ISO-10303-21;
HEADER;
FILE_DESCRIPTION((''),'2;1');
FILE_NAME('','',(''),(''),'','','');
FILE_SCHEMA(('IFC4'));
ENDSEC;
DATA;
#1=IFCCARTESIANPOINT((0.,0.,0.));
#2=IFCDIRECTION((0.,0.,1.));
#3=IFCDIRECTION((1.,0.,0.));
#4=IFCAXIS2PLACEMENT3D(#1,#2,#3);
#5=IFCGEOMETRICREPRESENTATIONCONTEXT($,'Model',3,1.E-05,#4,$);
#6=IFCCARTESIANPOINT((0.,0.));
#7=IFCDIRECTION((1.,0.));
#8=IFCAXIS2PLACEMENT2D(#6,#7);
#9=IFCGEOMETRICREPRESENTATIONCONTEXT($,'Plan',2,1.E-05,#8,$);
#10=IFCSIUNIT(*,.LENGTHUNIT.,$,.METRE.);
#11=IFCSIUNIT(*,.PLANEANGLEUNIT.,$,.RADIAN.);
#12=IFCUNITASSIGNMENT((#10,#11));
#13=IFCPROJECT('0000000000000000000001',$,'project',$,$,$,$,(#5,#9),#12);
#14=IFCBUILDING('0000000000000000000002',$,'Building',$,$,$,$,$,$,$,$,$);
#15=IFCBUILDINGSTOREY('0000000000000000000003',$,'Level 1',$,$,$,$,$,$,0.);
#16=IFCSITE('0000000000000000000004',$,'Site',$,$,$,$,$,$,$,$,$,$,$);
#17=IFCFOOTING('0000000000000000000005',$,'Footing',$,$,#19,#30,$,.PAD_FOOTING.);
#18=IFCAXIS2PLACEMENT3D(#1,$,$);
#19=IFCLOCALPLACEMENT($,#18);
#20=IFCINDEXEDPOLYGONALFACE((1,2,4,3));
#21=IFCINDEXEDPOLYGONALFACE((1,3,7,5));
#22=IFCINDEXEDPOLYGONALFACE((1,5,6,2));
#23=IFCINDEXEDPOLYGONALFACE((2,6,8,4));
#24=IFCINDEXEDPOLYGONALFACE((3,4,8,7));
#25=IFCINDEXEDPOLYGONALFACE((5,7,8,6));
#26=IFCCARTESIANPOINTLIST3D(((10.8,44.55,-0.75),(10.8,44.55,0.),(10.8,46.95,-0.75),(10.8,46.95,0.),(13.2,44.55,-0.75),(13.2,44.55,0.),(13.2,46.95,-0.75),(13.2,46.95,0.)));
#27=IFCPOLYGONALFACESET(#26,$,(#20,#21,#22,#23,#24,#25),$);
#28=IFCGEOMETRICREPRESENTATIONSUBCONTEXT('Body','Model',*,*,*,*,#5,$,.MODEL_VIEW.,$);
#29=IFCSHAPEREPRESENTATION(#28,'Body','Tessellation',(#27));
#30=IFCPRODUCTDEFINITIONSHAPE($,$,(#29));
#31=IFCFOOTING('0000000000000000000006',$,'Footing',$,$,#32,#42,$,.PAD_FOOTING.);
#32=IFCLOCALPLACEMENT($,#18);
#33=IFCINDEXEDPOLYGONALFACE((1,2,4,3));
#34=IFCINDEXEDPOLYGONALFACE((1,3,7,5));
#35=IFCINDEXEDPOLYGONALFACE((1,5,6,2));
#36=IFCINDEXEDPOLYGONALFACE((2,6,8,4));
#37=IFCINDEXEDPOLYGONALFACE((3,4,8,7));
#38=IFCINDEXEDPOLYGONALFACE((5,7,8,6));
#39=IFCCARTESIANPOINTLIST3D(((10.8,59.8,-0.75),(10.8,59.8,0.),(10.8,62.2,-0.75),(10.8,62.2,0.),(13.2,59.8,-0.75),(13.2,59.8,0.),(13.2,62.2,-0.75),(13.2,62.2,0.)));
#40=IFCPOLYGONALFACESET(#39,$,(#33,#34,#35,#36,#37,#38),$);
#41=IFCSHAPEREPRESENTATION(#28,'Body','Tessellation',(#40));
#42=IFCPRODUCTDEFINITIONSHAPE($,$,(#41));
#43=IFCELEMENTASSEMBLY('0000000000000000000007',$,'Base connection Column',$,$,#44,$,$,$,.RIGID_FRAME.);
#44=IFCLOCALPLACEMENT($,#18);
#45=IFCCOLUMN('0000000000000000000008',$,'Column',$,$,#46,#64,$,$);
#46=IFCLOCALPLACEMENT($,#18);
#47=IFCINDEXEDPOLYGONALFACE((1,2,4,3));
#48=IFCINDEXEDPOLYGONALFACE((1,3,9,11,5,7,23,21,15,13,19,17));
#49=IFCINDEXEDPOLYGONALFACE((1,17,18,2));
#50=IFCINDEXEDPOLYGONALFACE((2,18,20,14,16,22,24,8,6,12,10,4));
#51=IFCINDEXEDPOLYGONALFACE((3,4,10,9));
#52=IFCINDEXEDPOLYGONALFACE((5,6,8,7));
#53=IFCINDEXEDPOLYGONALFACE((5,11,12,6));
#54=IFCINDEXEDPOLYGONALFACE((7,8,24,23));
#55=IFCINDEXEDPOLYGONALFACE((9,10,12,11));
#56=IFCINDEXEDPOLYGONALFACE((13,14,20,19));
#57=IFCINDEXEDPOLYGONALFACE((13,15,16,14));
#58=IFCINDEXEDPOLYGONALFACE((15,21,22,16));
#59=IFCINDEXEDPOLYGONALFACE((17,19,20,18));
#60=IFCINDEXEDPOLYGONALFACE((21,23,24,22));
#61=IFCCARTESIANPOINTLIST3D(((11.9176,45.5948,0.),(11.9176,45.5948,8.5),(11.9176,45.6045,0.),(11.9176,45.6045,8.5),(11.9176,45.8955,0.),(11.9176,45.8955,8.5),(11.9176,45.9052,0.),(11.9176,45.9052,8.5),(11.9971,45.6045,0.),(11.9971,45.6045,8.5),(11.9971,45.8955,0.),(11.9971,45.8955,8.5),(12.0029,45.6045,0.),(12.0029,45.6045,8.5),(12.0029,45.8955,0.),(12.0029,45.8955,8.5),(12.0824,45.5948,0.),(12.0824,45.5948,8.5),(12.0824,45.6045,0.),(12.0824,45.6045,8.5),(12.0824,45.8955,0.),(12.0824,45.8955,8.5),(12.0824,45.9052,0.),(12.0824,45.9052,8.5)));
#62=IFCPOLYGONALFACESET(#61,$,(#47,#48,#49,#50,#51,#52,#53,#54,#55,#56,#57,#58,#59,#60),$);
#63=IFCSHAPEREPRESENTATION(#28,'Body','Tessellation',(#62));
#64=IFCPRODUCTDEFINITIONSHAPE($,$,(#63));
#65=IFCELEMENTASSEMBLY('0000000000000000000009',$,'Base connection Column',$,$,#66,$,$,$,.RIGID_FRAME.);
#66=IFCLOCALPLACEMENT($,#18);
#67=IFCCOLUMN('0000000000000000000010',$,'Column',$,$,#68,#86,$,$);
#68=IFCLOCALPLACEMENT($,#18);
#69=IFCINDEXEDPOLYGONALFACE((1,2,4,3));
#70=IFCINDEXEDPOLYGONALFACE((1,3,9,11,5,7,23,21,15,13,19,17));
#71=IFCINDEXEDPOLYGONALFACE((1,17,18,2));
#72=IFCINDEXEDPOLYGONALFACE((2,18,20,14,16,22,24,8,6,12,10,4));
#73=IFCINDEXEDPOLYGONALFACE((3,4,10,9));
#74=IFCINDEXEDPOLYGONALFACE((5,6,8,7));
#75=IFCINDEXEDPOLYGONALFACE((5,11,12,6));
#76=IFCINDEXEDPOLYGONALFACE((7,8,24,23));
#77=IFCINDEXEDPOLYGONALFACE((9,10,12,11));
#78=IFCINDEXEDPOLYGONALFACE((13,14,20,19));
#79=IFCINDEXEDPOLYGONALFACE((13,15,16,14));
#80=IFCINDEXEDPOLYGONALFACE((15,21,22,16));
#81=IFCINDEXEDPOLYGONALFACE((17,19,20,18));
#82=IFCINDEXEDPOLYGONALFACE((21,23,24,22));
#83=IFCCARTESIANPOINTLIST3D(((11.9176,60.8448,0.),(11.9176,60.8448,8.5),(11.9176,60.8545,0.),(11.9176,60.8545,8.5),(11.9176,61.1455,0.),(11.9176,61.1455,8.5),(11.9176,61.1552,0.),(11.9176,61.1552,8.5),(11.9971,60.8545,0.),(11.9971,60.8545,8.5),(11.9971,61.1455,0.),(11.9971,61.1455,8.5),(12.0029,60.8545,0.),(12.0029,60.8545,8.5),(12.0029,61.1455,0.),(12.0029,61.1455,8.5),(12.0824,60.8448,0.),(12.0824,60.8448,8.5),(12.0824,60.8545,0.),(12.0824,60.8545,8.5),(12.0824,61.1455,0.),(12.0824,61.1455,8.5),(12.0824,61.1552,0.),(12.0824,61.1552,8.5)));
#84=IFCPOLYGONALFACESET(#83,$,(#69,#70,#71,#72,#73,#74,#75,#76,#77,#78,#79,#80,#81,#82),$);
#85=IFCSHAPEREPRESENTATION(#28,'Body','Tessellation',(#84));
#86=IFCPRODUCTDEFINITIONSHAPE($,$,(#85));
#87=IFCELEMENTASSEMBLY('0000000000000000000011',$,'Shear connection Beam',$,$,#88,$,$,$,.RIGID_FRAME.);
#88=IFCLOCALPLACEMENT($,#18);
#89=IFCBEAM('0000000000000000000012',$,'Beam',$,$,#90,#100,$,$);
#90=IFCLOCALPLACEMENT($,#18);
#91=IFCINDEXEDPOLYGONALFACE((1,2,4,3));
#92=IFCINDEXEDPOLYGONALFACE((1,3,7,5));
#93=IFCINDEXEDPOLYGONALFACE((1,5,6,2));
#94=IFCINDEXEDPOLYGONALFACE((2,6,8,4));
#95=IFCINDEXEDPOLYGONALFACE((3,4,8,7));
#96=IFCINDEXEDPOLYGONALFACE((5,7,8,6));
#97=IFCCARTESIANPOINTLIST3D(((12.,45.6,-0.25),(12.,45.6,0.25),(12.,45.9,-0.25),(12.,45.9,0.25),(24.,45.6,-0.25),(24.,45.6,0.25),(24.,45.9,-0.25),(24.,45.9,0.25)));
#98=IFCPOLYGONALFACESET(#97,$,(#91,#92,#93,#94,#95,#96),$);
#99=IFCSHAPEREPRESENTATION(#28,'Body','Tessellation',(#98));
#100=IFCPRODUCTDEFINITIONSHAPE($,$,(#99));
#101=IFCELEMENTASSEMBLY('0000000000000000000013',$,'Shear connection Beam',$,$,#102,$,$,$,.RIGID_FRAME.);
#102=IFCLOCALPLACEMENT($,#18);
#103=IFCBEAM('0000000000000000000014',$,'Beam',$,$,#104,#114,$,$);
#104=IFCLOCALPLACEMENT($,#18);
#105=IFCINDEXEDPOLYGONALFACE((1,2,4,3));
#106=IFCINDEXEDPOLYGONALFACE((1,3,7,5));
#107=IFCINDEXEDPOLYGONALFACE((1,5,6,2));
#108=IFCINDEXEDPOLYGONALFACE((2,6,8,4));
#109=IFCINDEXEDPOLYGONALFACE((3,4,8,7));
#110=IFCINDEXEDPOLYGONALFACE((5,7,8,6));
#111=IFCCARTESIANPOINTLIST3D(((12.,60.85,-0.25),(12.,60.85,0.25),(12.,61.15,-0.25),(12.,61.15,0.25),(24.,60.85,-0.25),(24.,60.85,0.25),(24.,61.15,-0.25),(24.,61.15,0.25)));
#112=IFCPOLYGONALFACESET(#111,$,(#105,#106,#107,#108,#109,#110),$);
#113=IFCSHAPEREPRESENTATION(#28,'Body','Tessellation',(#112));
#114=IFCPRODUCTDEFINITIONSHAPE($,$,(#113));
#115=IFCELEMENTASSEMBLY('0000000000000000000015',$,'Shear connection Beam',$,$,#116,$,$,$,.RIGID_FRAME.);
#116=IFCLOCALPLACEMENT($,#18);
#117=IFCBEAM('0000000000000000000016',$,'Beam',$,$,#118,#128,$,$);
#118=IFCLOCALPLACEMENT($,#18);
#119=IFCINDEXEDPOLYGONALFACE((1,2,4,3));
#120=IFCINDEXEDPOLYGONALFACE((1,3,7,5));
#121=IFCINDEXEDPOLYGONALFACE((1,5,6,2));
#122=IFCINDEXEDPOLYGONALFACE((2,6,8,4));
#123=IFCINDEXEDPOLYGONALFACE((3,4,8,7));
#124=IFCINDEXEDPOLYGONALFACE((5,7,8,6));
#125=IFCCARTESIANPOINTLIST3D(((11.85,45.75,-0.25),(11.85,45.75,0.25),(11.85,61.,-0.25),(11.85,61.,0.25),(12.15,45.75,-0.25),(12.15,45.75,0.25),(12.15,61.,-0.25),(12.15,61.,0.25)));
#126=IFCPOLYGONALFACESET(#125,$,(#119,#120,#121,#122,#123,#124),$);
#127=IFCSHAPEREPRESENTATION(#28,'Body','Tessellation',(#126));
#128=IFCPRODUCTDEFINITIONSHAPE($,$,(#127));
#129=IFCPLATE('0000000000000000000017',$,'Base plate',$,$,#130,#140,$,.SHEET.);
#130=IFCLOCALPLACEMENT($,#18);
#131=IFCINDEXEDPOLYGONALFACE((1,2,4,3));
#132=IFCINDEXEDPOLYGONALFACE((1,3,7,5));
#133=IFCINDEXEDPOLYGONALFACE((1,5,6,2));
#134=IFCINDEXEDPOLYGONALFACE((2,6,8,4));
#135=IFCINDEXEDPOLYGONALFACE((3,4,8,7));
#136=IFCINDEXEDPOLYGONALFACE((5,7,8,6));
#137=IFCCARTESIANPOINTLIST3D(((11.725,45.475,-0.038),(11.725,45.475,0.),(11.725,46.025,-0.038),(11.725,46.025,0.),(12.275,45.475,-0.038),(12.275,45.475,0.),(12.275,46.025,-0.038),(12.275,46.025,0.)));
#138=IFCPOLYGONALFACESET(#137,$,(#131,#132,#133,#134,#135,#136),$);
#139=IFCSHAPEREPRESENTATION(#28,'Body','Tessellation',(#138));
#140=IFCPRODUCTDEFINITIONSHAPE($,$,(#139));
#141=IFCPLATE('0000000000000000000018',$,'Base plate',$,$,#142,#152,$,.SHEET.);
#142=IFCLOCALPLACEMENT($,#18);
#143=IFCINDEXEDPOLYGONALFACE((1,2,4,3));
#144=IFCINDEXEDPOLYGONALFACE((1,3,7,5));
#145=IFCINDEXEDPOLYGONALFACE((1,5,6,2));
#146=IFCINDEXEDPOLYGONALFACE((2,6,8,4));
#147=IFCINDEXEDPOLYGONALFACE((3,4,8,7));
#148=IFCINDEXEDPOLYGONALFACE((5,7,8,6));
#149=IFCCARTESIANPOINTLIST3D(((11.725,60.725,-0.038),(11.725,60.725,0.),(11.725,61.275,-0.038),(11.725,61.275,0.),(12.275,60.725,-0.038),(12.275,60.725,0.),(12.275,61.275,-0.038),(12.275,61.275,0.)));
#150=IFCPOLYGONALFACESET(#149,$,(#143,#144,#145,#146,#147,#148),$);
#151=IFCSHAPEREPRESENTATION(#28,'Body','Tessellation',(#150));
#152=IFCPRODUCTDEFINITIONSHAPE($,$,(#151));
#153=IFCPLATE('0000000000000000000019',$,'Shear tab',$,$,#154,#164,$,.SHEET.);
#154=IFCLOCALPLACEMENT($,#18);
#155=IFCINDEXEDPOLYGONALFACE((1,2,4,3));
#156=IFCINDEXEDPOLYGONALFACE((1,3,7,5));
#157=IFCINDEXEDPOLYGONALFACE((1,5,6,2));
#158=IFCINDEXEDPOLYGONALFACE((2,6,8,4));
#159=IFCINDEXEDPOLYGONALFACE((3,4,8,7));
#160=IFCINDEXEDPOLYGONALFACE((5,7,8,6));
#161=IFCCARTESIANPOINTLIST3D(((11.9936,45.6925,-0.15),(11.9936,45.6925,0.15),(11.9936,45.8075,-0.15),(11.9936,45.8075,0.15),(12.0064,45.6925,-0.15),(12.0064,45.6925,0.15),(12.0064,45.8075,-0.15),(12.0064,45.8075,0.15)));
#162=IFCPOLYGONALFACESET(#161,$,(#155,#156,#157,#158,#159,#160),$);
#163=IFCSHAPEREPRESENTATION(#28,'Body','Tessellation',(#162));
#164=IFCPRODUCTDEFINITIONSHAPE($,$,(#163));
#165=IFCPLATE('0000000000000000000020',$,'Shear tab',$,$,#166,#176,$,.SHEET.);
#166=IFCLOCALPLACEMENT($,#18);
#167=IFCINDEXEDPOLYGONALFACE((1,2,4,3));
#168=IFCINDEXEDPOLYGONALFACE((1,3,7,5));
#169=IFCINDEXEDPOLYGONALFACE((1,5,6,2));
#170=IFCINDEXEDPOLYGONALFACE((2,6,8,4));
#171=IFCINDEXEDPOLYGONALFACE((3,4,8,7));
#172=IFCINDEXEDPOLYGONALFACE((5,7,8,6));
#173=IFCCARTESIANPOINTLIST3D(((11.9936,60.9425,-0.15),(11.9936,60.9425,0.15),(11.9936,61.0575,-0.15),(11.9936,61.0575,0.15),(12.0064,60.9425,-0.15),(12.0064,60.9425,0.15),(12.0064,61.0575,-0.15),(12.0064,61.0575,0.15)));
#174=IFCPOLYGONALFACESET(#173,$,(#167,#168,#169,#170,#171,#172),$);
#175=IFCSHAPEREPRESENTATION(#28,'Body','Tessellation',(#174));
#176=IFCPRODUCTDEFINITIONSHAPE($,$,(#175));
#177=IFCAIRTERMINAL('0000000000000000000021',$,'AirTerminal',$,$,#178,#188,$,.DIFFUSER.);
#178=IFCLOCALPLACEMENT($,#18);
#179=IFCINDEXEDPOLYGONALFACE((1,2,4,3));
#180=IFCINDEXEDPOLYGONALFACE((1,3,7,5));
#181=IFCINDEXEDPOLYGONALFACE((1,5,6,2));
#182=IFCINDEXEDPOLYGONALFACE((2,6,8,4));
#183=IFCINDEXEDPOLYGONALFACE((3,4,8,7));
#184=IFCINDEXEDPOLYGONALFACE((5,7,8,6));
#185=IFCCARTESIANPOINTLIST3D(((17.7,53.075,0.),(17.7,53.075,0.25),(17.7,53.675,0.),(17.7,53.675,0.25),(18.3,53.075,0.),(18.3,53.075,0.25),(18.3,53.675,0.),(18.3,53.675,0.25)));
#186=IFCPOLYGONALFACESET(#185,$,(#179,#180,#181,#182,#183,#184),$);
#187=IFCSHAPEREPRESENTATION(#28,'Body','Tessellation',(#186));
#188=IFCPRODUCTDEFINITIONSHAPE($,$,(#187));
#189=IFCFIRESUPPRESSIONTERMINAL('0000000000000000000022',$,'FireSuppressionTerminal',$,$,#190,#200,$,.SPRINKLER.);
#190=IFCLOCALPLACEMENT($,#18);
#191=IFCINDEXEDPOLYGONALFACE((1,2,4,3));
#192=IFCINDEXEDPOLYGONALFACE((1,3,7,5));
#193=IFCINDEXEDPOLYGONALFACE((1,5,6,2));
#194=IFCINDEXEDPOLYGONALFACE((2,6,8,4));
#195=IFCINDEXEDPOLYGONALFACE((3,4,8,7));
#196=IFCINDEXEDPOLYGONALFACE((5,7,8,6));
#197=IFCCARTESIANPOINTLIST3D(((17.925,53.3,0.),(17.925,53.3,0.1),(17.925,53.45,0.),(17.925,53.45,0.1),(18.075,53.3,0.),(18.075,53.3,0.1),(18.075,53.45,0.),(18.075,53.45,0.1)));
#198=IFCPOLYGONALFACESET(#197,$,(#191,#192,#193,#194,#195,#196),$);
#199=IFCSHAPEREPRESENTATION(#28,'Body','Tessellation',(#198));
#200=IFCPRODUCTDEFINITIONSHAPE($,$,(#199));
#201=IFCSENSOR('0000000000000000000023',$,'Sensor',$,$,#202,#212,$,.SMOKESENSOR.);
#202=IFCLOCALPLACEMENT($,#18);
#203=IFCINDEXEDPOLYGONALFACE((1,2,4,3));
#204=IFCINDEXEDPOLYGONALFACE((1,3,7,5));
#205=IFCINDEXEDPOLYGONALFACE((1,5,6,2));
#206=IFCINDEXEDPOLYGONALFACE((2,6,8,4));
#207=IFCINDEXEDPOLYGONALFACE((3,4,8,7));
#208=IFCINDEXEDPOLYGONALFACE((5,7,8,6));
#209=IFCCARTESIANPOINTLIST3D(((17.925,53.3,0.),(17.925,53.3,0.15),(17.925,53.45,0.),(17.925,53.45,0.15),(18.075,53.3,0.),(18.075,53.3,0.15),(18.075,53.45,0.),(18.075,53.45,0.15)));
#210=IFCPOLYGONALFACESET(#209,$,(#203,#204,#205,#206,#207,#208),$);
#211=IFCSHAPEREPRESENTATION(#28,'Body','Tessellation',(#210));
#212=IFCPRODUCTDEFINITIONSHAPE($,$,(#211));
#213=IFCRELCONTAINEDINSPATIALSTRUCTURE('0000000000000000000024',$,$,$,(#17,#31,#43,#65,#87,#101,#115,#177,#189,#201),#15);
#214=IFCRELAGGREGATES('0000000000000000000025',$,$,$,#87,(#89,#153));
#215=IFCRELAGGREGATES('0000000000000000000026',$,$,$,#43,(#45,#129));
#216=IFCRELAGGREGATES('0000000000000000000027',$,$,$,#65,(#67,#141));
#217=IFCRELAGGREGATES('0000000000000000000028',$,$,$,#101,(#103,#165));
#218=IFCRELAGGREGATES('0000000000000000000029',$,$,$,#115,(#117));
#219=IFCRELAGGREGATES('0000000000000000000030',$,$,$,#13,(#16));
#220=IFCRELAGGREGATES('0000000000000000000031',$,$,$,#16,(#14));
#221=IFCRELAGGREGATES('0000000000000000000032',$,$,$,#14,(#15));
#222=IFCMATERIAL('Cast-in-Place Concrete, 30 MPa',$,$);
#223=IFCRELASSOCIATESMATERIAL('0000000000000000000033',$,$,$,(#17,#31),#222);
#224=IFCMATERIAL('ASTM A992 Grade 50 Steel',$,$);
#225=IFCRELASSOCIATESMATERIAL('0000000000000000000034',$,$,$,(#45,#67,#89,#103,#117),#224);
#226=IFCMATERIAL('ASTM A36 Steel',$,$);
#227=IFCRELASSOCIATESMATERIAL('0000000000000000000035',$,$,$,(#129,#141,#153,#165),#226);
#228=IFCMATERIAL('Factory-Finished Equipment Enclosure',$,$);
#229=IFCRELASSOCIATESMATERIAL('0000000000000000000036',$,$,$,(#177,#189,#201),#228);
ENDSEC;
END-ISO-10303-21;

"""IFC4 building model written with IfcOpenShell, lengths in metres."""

from ifc_helpers import new_model, si_unit, frame, origin_with_axes, origin_2d_with_axis, place, context, subcontext, project, spatial, rectangle, i_section, extrude, material, element, aggregate, save


model = new_model("IFC4")

# Units and contexts
model_context = context("Model", 3, precision=1e-05, world=origin_with_axes())
plan_context = context("Plan", 2, precision=1e-05, world=origin_2d_with_axis())
body_context = subcontext(model_context, "Body", "Model", "MODEL_VIEW")
ifc_project = project(units=[si_unit("LENGTHUNIT", "METRE"), si_unit("PLANEANGLEUNIT", "RADIAN")], contexts=[model_context, plan_context])

# Site, building, storey
site = spatial("IfcSite", under=ifc_project, Name="Site")
building = spatial("IfcBuilding", under=site, Name="Building")
storey = spatial("IfcBuildingStorey", under=building, Name="Level 1", Elevation=0.0)

# Footings
ifc_material_1 = material(Name="Cast-in-Place Concrete, 30 MPa")
for number, where, z_axis, x_axis, name in (
    (1, (12.0, 45.75, -0.75), (0.0, 0.0, 1.0), (1.0, 0.0, 0.0), "Footing"),
    (2, (12.0, 61.0, -0.75), (0.0, 0.0, 1.0), (1.0, 0.0, 0.0), "Footing"),
):
    element("IfcFooting", number, at=place(None, frame(where, z_axis=z_axis, x_axis=x_axis)), inside=storey, material=ifc_material_1, Name=name, PredefinedType="PAD_FOOTING", context=body_context, shape_type="SweptSolid", body=[
        extrude(rectangle(XDim=2.4, YDim=2.4, at=origin_2d_with_axis()), origin_with_axes(), (0.0, 0.0, 1.0), 0.75),
    ])

# Element assemblies, columns
assembly_1 = element("IfcElementAssembly", 3, inside=storey, Name="Base connection Column", PredefinedType="RIGID_FRAME")
ifc_material_2 = material(Name="ASTM A992 Grade 50 Steel")
column_1_placement = place(None, frame((12.0, 45.75, 0.0), z_axis=(0.0, 0.0, 1.0), x_axis=(1.0, 0.0, 0.0)))
column_1 = element("IfcColumn", 4, at=column_1_placement, material=ifc_material_2, Name="Column", context=body_context, shape_type="SweptSolid", body=[
    extrude(i_section(OverallWidth=0.1648, OverallDepth=0.3104, WebThickness=0.0058, FlangeThickness=0.0097, at=origin_2d_with_axis()), origin_with_axes(), (0.0, 0.0, 1.0), 8.5),
])
assembly_2 = element("IfcElementAssembly", 5, inside=storey, Name="Base connection Column", PredefinedType="RIGID_FRAME")
column_2_placement = place(None, frame((12.0, 61.0, 0.0), z_axis=(0.0, 0.0, 1.0), x_axis=(1.0, 0.0, 0.0)))
column_2 = element("IfcColumn", 6, at=column_2_placement, material=ifc_material_2, Name="Column", context=body_context, shape_type="SweptSolid", body=[
    extrude(i_section(OverallWidth=0.1648, OverallDepth=0.3104, WebThickness=0.0058, FlangeThickness=0.0097, at=origin_2d_with_axis()), origin_with_axes(), (0.0, 0.0, 1.0), 8.5),
])

# Element assemblies, beams
assembly_3 = element("IfcElementAssembly", 7, inside=storey, Name="Shear connection Beam", PredefinedType="RIGID_FRAME")
beam_1_placement = place(None, frame((12.0, 45.75, 0.0), z_axis=(1.0, 0.0, 0.0), x_axis=(0.0, 1.0, 0.0)))
beam_1 = element("IfcBeam", 8, at=beam_1_placement, material=ifc_material_2, Name="Beam", context=body_context, shape_type="SweptSolid", body=[
    extrude(rectangle(XDim=0.3, YDim=0.5, at=origin_2d_with_axis()), origin_with_axes(), (0.0, 0.0, 1.0), 12.0),
])
assembly_4 = element("IfcElementAssembly", 9, inside=storey, Name="Shear connection Beam", PredefinedType="RIGID_FRAME")
beam_2_placement = place(None, frame((12.0, 61.0, 0.0), z_axis=(1.0, 0.0, 0.0), x_axis=(0.0, 1.0, 0.0)))
beam_2 = element("IfcBeam", 10, at=beam_2_placement, material=ifc_material_2, Name="Beam", context=body_context, shape_type="SweptSolid", body=[
    extrude(rectangle(XDim=0.3, YDim=0.5, at=origin_2d_with_axis()), origin_with_axes(), (0.0, 0.0, 1.0), 12.0),
])
assembly_5 = element("IfcElementAssembly", 11, inside=storey, Name="Shear connection Beam", PredefinedType="RIGID_FRAME")
beam_3_placement = place(None, frame((12.0, 45.75, 0.0), z_axis=(0.0, 1.0, 0.0), x_axis=(-1.0, 0.0, 0.0)))
beam_3 = element("IfcBeam", 12, at=beam_3_placement, material=ifc_material_2, Name="Beam", context=body_context, shape_type="SweptSolid", body=[
    extrude(rectangle(XDim=0.3, YDim=0.5, at=origin_2d_with_axis()), origin_with_axes(), (0.0, 0.0, 1.0), 15.25),
])

# Plates
ifc_material_3 = material(Name="ASTM A36 Steel")
plate_1_placement = place(None, frame((12.0, 45.75, -0.038), z_axis=(0.0, 0.0, 1.0), x_axis=(1.0, 0.0, 0.0)))
plate_1 = element("IfcPlate", 13, at=plate_1_placement, material=ifc_material_3, Name="Base plate", PredefinedType="SHEET", context=body_context, shape_type="SweptSolid", body=[
    extrude(rectangle(XDim=0.55, YDim=0.55, at=origin_2d_with_axis()), origin_with_axes(), (0.0, 0.0, 1.0), 0.038),
])
plate_2_placement = place(None, frame((12.0, 61.0, -0.038), z_axis=(0.0, 0.0, 1.0), x_axis=(1.0, 0.0, 0.0)))
plate_2 = element("IfcPlate", 14, at=plate_2_placement, material=ifc_material_3, Name="Base plate", PredefinedType="SHEET", context=body_context, shape_type="SweptSolid", body=[
    extrude(rectangle(XDim=0.55, YDim=0.55, at=origin_2d_with_axis()), origin_with_axes(), (0.0, 0.0, 1.0), 0.038),
])
plate_3_placement = place(None, frame((12.0, 45.75, -0.15), z_axis=(0.0, 0.0, 1.0), x_axis=(1.0, 0.0, 0.0)))
plate_3 = element("IfcPlate", 15, at=plate_3_placement, material=ifc_material_3, Name="Shear tab", PredefinedType="SHEET", context=body_context, shape_type="SweptSolid", body=[
    extrude(rectangle(XDim=0.0127, YDim=0.115, at=origin_2d_with_axis()), origin_with_axes(), (0.0, 0.0, 1.0), 0.3),
])
aggregate(assembly_3, [beam_1, plate_3])
plate_4_placement = place(None, frame((12.0, 61.0, -0.15), z_axis=(0.0, 0.0, 1.0), x_axis=(1.0, 0.0, 0.0)))
plate_4 = element("IfcPlate", 16, at=plate_4_placement, material=ifc_material_3, Name="Shear tab", PredefinedType="SHEET", context=body_context, shape_type="SweptSolid", body=[
    extrude(rectangle(XDim=0.0127, YDim=0.115, at=origin_2d_with_axis()), origin_with_axes(), (0.0, 0.0, 1.0), 0.3),
])

# Air terminal
ifc_material_4 = material(Name="Factory-Finished Equipment Enclosure")
air_terminal_placement = place(None, frame((18.0, 53.375, 0.0), z_axis=(0.0, 0.0, 1.0), x_axis=(1.0, 0.0, 0.0)))
element("IfcAirTerminal", 17, at=air_terminal_placement, inside=storey, material=ifc_material_4, Name="AirTerminal", PredefinedType="DIFFUSER", context=body_context, shape_type="SweptSolid", body=[
    extrude(rectangle(XDim=0.6, YDim=0.6, at=origin_2d_with_axis()), origin_with_axes(), (0.0, 0.0, 1.0), 0.25),
])

# Fire suppression terminal
fire_suppression_terminal_placement = place(None, frame((18.0, 53.375, 0.0), z_axis=(0.0, 0.0, 1.0), x_axis=(1.0, 0.0, 0.0)))
element("IfcFireSuppressionTerminal", 18, at=fire_suppression_terminal_placement, inside=storey, material=ifc_material_4, Name="FireSuppressionTerminal", PredefinedType="SPRINKLER", context=body_context, shape_type="SweptSolid", body=[
    extrude(rectangle(XDim=0.15, YDim=0.15, at=origin_2d_with_axis()), origin_with_axes(), (0.0, 0.0, 1.0), 0.1),
])

# Sensor
sensor_placement = place(None, frame((18.0, 53.375, 0.0), z_axis=(0.0, 0.0, 1.0), x_axis=(1.0, 0.0, 0.0)))
element("IfcSensor", 19, at=sensor_placement, inside=storey, material=ifc_material_4, Name="Sensor", PredefinedType="SMOKESENSOR", context=body_context, shape_type="SweptSolid", body=[
    extrude(rectangle(XDim=0.15, YDim=0.15, at=origin_2d_with_axis()), origin_with_axes(), (0.0, 0.0, 1.0), 0.15),
])

aggregate(assembly_1, [column_1, plate_1])
aggregate(assembly_2, [column_2, plate_2])

aggregate(assembly_4, [beam_2, plate_4])
aggregate(assembly_5, [beam_3])

save(model, "model.ifc")
